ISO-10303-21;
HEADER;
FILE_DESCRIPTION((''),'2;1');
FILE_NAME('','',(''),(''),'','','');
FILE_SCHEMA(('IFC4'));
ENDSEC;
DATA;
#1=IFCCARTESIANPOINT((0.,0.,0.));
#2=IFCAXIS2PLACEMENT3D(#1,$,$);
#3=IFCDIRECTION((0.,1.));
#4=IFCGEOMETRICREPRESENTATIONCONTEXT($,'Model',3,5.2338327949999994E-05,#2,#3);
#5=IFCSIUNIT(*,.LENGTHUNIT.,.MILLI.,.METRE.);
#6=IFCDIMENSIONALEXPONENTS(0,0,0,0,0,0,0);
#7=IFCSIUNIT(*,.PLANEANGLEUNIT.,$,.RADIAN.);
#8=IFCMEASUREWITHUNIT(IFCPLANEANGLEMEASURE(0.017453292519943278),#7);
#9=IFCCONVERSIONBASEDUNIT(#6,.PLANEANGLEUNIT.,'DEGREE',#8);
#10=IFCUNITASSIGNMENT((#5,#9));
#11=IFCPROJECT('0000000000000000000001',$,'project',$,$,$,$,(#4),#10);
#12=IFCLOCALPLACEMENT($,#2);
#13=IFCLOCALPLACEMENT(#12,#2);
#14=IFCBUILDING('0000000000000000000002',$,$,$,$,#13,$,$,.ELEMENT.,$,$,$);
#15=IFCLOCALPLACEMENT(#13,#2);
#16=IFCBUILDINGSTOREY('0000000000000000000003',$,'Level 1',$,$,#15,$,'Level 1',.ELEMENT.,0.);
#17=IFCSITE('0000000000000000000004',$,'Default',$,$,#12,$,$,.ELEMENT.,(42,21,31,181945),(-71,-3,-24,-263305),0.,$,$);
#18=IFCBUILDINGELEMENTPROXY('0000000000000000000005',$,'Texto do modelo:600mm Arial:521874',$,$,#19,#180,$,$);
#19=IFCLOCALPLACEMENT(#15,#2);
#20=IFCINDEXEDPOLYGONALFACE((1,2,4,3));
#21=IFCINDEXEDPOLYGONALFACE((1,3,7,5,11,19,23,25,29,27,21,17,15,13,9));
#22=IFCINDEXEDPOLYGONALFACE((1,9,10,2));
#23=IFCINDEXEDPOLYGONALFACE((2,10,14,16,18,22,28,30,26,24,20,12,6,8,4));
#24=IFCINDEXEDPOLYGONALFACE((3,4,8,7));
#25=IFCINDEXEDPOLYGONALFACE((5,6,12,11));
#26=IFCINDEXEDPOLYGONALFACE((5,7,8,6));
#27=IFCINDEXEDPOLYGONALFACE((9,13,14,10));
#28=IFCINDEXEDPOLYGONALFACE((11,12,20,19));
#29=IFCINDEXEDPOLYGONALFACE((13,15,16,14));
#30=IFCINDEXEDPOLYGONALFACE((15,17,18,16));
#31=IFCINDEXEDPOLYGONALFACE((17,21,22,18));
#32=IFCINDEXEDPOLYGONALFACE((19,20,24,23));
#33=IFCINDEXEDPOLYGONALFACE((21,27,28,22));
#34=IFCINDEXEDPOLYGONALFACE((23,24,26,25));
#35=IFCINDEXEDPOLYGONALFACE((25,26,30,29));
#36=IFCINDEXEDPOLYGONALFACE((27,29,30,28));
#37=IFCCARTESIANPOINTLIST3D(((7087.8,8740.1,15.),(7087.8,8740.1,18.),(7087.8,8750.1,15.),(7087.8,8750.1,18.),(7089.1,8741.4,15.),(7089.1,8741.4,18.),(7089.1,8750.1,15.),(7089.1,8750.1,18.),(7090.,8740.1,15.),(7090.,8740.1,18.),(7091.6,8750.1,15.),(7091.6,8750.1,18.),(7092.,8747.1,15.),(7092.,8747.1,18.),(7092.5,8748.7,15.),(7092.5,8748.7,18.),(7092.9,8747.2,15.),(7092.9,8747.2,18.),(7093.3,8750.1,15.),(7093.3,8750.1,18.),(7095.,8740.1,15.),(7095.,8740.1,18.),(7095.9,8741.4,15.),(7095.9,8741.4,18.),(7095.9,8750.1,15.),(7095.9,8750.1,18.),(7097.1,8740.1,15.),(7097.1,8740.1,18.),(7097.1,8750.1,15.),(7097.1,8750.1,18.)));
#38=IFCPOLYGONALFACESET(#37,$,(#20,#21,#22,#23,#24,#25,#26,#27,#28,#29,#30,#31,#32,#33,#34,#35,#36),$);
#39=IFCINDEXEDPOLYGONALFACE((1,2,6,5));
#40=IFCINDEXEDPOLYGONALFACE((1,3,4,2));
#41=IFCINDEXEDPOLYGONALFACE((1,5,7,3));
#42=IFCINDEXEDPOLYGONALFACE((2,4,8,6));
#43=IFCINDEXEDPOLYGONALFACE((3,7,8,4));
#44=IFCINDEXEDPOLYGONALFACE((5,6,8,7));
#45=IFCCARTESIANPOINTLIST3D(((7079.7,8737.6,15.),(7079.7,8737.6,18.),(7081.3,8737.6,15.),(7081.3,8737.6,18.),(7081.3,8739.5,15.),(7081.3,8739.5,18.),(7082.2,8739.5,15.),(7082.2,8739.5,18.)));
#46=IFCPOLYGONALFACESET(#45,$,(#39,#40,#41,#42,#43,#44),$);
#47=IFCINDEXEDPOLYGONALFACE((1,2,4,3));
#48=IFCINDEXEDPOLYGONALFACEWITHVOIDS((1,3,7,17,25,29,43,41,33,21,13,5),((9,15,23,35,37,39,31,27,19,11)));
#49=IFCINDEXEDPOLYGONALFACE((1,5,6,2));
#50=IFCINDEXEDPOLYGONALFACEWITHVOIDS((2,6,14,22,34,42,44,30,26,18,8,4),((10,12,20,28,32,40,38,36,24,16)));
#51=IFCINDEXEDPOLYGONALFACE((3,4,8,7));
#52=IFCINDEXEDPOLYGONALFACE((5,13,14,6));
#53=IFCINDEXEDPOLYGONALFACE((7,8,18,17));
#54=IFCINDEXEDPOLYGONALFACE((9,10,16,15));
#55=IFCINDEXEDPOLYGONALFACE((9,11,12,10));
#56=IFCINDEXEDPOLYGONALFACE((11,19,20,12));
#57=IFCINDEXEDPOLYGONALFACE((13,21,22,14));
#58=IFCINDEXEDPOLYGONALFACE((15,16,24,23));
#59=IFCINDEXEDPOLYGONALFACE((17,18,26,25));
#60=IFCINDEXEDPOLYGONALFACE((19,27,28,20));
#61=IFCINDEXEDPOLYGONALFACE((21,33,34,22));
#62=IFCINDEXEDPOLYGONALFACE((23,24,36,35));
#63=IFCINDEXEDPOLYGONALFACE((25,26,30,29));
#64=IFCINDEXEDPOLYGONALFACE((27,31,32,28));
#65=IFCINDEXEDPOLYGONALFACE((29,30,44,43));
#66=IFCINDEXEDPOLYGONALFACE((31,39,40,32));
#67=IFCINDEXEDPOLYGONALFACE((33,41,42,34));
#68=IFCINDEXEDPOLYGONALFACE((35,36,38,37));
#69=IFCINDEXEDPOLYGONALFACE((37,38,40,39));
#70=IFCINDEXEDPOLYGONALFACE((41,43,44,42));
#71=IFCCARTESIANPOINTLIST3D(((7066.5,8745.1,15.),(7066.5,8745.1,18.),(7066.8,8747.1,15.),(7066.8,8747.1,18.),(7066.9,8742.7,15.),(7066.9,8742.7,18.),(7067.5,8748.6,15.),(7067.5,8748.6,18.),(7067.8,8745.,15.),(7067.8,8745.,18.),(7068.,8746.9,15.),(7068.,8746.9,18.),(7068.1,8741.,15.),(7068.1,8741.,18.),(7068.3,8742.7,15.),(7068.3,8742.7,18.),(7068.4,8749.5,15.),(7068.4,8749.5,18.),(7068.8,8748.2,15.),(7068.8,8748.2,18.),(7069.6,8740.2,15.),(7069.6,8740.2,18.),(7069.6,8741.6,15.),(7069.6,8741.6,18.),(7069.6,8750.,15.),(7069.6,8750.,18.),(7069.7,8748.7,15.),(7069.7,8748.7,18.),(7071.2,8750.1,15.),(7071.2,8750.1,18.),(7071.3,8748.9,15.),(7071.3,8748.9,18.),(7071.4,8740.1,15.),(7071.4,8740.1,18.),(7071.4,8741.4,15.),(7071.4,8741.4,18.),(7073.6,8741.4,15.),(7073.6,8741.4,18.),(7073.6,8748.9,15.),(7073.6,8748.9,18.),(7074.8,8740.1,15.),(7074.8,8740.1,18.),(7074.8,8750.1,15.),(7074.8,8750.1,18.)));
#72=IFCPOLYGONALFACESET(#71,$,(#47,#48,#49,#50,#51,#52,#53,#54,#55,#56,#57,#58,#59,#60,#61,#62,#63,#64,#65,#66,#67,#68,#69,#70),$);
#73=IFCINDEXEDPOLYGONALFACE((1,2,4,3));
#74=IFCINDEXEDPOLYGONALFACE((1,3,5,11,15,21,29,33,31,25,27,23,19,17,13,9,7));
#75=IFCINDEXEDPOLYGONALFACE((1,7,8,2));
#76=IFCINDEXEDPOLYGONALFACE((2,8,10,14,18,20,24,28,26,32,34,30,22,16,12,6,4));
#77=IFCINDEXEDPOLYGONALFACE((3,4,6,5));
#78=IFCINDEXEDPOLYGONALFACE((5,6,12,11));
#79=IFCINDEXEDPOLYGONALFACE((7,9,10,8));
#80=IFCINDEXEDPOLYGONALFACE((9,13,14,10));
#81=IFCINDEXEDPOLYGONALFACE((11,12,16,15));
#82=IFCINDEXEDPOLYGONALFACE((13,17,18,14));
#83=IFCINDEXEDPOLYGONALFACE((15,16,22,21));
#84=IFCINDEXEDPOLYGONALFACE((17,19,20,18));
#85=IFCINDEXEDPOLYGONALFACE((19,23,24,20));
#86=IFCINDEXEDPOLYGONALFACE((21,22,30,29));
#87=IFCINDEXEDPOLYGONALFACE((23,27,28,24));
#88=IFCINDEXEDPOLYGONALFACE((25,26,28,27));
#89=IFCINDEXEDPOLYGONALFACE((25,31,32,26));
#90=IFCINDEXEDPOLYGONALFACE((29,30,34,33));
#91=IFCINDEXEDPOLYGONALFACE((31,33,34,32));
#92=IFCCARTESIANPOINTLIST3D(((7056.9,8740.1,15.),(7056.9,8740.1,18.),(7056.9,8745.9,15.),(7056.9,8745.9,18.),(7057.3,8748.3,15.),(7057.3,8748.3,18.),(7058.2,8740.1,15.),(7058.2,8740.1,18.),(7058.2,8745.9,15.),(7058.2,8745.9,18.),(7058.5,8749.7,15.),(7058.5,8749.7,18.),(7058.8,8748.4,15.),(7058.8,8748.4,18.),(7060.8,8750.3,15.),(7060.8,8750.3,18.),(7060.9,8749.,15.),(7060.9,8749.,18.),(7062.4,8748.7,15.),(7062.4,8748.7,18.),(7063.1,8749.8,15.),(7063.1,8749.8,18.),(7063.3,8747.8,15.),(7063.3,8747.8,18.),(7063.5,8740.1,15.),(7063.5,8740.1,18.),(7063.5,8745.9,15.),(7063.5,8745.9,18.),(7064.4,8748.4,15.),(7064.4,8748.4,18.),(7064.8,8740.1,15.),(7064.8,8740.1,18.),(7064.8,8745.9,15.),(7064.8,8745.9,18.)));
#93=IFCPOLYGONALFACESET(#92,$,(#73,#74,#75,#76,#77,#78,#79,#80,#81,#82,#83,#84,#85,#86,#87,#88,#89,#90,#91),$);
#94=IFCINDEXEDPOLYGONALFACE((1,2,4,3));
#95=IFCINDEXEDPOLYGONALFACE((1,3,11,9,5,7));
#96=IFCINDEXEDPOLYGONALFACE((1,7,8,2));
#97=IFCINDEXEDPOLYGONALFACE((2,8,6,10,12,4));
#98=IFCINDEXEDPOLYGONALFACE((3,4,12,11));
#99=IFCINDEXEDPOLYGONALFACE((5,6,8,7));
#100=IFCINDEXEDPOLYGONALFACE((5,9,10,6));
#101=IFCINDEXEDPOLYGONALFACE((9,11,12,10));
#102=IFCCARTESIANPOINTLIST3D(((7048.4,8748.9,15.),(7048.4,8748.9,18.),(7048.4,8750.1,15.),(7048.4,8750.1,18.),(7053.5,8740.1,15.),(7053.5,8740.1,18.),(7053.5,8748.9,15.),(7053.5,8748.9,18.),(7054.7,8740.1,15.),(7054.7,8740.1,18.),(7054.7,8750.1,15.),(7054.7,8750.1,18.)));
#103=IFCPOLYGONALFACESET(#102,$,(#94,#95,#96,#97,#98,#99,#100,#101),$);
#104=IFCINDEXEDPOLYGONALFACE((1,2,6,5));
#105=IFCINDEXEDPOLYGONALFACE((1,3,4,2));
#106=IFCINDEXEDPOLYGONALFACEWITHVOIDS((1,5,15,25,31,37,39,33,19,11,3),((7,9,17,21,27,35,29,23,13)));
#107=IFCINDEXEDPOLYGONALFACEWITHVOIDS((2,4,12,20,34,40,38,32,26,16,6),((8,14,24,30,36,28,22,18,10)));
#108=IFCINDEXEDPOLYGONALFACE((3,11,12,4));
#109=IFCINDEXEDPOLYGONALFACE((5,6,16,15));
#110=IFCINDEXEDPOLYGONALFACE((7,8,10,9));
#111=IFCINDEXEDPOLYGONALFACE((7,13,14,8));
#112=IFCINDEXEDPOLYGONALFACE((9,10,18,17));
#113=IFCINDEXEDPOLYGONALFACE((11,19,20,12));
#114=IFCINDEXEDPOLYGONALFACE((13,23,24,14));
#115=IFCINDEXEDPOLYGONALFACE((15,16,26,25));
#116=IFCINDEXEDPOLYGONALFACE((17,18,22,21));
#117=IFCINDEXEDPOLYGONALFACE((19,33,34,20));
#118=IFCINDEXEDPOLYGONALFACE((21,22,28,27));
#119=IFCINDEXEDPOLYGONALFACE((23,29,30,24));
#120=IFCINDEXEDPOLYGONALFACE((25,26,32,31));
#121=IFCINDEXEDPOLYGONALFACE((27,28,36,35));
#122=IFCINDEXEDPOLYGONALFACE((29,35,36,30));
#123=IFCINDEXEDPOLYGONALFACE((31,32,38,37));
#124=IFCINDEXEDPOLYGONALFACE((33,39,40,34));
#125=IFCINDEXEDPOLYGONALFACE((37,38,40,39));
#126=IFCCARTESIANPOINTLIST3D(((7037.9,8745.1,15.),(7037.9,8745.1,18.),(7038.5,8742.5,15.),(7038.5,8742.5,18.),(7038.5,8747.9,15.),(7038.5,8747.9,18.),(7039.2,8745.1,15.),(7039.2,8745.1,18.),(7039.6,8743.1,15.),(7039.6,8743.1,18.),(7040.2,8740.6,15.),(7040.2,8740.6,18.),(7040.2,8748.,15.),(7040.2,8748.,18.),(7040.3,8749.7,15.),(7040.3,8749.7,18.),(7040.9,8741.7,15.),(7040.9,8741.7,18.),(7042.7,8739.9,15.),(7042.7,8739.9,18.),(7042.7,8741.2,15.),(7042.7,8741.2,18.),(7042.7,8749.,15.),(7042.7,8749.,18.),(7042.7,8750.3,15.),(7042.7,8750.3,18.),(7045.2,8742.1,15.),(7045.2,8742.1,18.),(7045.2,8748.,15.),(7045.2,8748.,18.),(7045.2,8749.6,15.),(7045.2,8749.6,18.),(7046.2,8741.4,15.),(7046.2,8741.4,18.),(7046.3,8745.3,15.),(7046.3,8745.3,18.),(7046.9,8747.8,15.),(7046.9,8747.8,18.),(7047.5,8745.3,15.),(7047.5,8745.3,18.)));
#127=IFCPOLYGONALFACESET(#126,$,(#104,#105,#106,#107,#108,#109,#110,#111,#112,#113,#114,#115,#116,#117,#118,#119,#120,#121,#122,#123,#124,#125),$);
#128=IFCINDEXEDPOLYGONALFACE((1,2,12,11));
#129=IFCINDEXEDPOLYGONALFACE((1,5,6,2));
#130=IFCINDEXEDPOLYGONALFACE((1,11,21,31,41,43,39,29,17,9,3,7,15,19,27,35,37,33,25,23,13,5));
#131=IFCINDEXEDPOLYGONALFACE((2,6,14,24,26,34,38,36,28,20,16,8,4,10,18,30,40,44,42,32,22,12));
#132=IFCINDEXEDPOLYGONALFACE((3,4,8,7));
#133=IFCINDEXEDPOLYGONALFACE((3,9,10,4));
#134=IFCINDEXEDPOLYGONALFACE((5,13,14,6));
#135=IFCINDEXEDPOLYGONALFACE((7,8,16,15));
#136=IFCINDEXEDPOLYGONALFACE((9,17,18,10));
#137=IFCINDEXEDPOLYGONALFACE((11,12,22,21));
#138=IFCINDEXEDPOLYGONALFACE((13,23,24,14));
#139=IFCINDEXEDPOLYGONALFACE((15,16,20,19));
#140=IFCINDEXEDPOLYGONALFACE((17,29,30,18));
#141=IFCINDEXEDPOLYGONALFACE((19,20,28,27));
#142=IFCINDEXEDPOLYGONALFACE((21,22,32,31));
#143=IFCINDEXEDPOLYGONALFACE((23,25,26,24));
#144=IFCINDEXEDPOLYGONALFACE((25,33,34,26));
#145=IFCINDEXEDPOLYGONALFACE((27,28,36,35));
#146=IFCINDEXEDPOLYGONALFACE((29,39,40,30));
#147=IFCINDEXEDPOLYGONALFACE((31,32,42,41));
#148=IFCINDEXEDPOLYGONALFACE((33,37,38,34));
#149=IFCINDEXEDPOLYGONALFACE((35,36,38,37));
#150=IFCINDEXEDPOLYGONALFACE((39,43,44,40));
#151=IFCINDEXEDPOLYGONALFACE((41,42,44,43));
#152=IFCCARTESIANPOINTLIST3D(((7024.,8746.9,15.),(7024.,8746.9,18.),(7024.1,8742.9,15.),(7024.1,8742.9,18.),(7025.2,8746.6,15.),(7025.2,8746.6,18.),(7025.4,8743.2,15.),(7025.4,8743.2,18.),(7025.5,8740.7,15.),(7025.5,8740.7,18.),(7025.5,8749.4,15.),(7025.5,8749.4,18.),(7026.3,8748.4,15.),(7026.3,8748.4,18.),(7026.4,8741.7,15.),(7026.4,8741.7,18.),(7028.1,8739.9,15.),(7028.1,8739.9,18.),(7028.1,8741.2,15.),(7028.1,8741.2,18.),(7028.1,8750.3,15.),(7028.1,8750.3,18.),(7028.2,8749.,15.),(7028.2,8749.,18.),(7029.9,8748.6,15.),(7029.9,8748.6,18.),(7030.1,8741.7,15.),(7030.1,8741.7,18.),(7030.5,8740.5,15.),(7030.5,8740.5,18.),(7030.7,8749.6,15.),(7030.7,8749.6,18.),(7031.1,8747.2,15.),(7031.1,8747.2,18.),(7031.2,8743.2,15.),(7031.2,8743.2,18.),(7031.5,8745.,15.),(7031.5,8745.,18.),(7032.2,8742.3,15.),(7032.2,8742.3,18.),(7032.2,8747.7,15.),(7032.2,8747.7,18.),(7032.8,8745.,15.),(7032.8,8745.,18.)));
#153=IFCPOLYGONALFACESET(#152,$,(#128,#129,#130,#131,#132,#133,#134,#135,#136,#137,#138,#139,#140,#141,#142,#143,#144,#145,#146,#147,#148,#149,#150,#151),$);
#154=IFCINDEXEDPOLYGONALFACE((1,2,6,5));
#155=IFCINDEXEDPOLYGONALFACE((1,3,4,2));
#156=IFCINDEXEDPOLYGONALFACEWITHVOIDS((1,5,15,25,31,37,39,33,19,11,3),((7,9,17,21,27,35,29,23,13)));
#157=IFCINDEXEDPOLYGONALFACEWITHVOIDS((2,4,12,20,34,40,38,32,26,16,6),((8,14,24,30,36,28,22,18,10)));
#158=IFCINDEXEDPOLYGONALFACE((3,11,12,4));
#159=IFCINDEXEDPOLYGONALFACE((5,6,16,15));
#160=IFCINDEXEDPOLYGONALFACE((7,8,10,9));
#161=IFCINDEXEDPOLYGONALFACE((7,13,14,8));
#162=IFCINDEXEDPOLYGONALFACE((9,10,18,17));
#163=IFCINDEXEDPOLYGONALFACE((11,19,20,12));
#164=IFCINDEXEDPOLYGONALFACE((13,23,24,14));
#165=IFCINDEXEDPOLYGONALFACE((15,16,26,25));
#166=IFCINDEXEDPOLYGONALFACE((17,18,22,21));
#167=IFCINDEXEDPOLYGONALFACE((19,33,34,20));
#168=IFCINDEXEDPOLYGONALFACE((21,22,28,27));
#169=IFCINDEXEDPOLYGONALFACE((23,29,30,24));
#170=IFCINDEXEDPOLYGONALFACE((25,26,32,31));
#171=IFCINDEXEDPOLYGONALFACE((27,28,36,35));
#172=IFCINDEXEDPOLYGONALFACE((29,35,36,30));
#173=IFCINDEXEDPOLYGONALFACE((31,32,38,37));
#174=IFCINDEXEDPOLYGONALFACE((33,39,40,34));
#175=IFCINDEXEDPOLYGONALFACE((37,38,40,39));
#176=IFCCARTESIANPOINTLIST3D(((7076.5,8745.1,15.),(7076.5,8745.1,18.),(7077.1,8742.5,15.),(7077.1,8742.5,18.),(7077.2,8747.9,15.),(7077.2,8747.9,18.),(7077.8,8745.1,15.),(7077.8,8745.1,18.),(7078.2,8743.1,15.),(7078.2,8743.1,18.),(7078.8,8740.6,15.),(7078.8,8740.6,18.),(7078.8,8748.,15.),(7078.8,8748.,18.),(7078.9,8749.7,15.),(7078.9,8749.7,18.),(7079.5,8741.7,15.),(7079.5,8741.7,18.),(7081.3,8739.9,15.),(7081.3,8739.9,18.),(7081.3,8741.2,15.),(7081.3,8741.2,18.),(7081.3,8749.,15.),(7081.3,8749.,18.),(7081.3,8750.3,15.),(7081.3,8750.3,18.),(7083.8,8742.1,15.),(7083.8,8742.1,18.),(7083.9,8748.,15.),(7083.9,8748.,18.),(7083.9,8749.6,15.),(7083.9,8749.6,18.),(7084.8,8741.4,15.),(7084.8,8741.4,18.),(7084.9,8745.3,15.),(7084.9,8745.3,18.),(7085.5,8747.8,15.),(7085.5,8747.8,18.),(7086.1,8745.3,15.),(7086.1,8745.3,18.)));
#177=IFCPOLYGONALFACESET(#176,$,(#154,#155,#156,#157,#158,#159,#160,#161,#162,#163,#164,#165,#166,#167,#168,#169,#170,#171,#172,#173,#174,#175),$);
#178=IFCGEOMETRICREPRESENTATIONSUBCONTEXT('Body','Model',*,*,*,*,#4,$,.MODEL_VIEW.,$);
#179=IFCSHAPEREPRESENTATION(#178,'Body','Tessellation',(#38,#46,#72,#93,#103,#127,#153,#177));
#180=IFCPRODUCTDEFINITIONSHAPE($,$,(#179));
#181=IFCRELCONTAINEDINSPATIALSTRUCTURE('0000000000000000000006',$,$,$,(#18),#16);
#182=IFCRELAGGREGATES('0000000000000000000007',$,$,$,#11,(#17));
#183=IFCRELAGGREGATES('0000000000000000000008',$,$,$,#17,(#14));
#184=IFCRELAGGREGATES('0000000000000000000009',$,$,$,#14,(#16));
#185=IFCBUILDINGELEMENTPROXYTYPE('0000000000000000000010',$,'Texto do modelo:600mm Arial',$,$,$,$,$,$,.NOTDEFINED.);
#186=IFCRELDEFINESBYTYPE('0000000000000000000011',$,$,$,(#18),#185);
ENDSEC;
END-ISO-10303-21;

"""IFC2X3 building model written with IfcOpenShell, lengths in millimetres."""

from ifc_helpers import new_model, entity, si_unit, converted_unit, direction, frame, origin, place, context, subcontext, project, spatial, polyline, outline, extrude, type_object, element, save


model = new_model("IFC2X3")

# Units and contexts
model_context = context("Model", 3, precision=5.2338327949999994e-05, world=origin(), true_north=direction((0.0, 1.0)))
body_context = subcontext(model_context, "Body", "Model", "MODEL_VIEW")
ifc_project = project(units=[si_unit("LENGTHUNIT", "METRE", prefix="MILLI"), converted_unit("PLANEANGLEUNIT", "DEGREE", entity("IfcPlaneAngleMeasure", 0.017453292519943278), si_unit("PLANEANGLEUNIT", "RADIAN"), dimensions=[0, 0, 0, 0, 0, 0, 0])], contexts=[model_context])

# Site, building, storey
site_placement = place(None, origin())
site = spatial("IfcSite", under=ifc_project, at=site_placement, Name="Default", CompositionType="ELEMENT", RefLatitude=(42, 21, 31, 181945), RefLongitude=(-71, -3, -24, -263305), RefElevation=0.0)
building_placement = place(site_placement, origin())
building = spatial("IfcBuilding", under=site, at=building_placement, CompositionType="ELEMENT")
storey_placement = place(building_placement, origin())
storey = spatial("IfcBuildingStorey", under=building, at=storey_placement, Name="Level 1", LongName="Level 1", CompositionType="ELEMENT", Elevation=0.0)

# Building element proxy
building_element_proxy_type_1 = type_object("IfcBuildingElementProxyType", Name="Texto do modelo:600mm Arial", PredefinedType="NOTDEFINED")
proxy_1_placement = place(storey_placement, origin())
element("IfcBuildingElementProxy", 1, at=proxy_1_placement, inside=storey, type_object=building_element_proxy_type_1, Name="Texto do modelo:600mm Arial:521874", context=body_context, shape_type="SweptSolid", body=[
    extrude(outline(polyline([(-4.6, -4.4), (-3.4, -4.4), (-3.4, 4.4), (-0.9, -4.4), (0.8, -4.4), (3.4, 4.4), (3.4, -4.4), (4.6, -4.4), (4.6, 5.7), (2.5, 5.7), (0.4, -1.3), (0.0, -2.9), (-0.4, -1.4), (-2.5, 5.7), (-4.6, 5.7), (-4.6, -4.4)])), frame((7092.5, 8745.8, 15.0), z_axis=(0.0, 0.0, 1.0), x_axis=(-1.0, 0.0, 0.0)), (0.0, 0.0, 1.0), 3.0),
    extrude(outline(polyline([(-1.1, -0.9), (-0.2, -0.9), (1.4, 0.9), (-0.2, 0.9), (-1.1, -0.9)])), frame((7081.1, 8738.5, 15.0), z_axis=(0.0, 0.0, 1.0), x_axis=(-1.0, 0.0, 0.0)), (0.0, 0.0, 1.0), 3.0),
    extrude(outline(polyline([(-5.2, -4.8), (-1.6, -4.8), (0.0, -4.6), (1.2, -4.1), (2.2, -3.2), (2.8, -1.7), (3.1, 0.3), (2.7, 2.7), (1.5, 4.4), (0.1, 5.1), (-1.7, 5.3), (-5.2, 5.3), (-5.2, -4.8)]), holes=[polyline([(-3.9, -3.5), (-3.9, 4.0), (-1.8, 4.0), (0.0, 3.8), (1.3, 2.7), (1.9, 0.3), (1.6, -1.6), (0.8, -2.8), (-0.1, -3.3), (-1.7, -3.5), (-3.9, -3.5)])]), frame((7069.6, 8745.4, 15.0), z_axis=(0.0, 0.0, 1.0), x_axis=(-1.0, 0.0, 0.0)), (0.0, 0.0, 1.0), 3.0),
    extrude(outline(polyline([(-6.0, -2.8), (-6.0, -4.0), (-0.2, -4.0), (2.2, -3.7), (3.6, -2.5), (4.2, -0.1), (3.7, 2.2), (2.3, 3.4), (-0.2, 3.8), (-6.0, 3.8), (-6.0, 2.6), (-0.3, 2.6), (1.6, 2.3), (2.6, 1.5), (2.9, 0.0), (2.2, -2.1), (-0.3, -2.8), (-6.0, -2.8)])), frame((7061.0, 8746.1, 15.0), z_axis=(0.0, 0.0, -1.0), x_axis=(0.0, 1.0, 0.0)), (0.0, 0.0, -1.0), 3.0),
    extrude(outline(polyline([(-2.5, -3.8), (3.8, -3.8), (3.8, -2.5), (-1.3, -2.5), (-1.3, 6.3), (-2.5, 6.3), (-2.5, -3.8)])), frame((7052.2, 8746.4, 15.0), z_axis=(0.0, 0.0, 1.0), x_axis=(-1.0, 0.0, 0.0)), (0.0, 0.0, 1.0), 3.0),
    extrude(outline(polyline([(-1.3, -4.9), (1.2, -4.9), (3.4, -3.7), (4.7, -1.4), (4.6, 1.1), (3.2, 3.2), (0.7, 4.5), (-2.0, 4.5), (-4.2, 3.2), (-5.4, 1.0), (-4.8, -2.7), (-1.3, -4.9)]), holes=[polyline([(-1.0, -3.7), (-3.9, -2.0), (-4.2, 0.7), (-3.3, 2.4), (-1.7, 3.3), (0.4, 3.2), (3.0, 1.6), (3.4, -1.1), (1.9, -3.3), (-1.0, -3.7)])]), frame((7042.4, 8745.5, 15.0), z_axis=(0.0, 0.0, 1.0), x_axis=(-0.223707, 0.974656, 0.0)), (0.0, 0.0, 1.0), 3.0),
    extrude(outline(polyline([(-0.3, -3.6), (-0.7, -4.8), (2.3, -4.8), (4.3, -3.0), (5.1, -0.4), (4.2, 1.9), (2.1, 3.7), (-0.6, 4.5), (-2.9, 4.0), (-4.7, 2.2), (-5.2, -0.4), (-4.0, -2.7), (-3.1, -1.8), (-4.0, -0.1), (-3.5, 1.6), (-2.1, 3.0), (-0.3, 3.3), (1.5, 2.6), (3.2, 1.2), (3.8, -0.5), (3.3, -2.2), (1.8, -3.6), (-0.3, -3.6)])), frame((7028.5, 8745.1, 15.0), z_axis=(0.0, 0.0, -1.0), x_axis=(0.499291, 0.866434, 0.0)), (0.0, 0.0, -1.0), 3.0),
    extrude(outline(polyline([(-1.3, -4.9), (1.2, -4.9), (3.4, -3.7), (4.7, -1.4), (4.6, 1.1), (3.2, 3.2), (0.7, 4.5), (-2.0, 4.5), (-4.2, 3.2), (-5.4, 1.0), (-4.8, -2.7), (-1.3, -4.9)]), holes=[polyline([(-1.0, -3.7), (-3.9, -2.0), (-4.2, 0.7), (-3.3, 2.4), (-1.7, 3.3), (0.4, 3.2), (3.0, 1.6), (3.4, -1.1), (1.9, -3.3), (-1.0, -3.7)])]), frame((7081.0, 8745.5, 15.0), z_axis=(0.0, 0.0, 1.0), x_axis=(-0.223707, 0.974656, 0.0)), (0.0, 0.0, 1.0), 3.0),
])

save(model, "model.ifc")
